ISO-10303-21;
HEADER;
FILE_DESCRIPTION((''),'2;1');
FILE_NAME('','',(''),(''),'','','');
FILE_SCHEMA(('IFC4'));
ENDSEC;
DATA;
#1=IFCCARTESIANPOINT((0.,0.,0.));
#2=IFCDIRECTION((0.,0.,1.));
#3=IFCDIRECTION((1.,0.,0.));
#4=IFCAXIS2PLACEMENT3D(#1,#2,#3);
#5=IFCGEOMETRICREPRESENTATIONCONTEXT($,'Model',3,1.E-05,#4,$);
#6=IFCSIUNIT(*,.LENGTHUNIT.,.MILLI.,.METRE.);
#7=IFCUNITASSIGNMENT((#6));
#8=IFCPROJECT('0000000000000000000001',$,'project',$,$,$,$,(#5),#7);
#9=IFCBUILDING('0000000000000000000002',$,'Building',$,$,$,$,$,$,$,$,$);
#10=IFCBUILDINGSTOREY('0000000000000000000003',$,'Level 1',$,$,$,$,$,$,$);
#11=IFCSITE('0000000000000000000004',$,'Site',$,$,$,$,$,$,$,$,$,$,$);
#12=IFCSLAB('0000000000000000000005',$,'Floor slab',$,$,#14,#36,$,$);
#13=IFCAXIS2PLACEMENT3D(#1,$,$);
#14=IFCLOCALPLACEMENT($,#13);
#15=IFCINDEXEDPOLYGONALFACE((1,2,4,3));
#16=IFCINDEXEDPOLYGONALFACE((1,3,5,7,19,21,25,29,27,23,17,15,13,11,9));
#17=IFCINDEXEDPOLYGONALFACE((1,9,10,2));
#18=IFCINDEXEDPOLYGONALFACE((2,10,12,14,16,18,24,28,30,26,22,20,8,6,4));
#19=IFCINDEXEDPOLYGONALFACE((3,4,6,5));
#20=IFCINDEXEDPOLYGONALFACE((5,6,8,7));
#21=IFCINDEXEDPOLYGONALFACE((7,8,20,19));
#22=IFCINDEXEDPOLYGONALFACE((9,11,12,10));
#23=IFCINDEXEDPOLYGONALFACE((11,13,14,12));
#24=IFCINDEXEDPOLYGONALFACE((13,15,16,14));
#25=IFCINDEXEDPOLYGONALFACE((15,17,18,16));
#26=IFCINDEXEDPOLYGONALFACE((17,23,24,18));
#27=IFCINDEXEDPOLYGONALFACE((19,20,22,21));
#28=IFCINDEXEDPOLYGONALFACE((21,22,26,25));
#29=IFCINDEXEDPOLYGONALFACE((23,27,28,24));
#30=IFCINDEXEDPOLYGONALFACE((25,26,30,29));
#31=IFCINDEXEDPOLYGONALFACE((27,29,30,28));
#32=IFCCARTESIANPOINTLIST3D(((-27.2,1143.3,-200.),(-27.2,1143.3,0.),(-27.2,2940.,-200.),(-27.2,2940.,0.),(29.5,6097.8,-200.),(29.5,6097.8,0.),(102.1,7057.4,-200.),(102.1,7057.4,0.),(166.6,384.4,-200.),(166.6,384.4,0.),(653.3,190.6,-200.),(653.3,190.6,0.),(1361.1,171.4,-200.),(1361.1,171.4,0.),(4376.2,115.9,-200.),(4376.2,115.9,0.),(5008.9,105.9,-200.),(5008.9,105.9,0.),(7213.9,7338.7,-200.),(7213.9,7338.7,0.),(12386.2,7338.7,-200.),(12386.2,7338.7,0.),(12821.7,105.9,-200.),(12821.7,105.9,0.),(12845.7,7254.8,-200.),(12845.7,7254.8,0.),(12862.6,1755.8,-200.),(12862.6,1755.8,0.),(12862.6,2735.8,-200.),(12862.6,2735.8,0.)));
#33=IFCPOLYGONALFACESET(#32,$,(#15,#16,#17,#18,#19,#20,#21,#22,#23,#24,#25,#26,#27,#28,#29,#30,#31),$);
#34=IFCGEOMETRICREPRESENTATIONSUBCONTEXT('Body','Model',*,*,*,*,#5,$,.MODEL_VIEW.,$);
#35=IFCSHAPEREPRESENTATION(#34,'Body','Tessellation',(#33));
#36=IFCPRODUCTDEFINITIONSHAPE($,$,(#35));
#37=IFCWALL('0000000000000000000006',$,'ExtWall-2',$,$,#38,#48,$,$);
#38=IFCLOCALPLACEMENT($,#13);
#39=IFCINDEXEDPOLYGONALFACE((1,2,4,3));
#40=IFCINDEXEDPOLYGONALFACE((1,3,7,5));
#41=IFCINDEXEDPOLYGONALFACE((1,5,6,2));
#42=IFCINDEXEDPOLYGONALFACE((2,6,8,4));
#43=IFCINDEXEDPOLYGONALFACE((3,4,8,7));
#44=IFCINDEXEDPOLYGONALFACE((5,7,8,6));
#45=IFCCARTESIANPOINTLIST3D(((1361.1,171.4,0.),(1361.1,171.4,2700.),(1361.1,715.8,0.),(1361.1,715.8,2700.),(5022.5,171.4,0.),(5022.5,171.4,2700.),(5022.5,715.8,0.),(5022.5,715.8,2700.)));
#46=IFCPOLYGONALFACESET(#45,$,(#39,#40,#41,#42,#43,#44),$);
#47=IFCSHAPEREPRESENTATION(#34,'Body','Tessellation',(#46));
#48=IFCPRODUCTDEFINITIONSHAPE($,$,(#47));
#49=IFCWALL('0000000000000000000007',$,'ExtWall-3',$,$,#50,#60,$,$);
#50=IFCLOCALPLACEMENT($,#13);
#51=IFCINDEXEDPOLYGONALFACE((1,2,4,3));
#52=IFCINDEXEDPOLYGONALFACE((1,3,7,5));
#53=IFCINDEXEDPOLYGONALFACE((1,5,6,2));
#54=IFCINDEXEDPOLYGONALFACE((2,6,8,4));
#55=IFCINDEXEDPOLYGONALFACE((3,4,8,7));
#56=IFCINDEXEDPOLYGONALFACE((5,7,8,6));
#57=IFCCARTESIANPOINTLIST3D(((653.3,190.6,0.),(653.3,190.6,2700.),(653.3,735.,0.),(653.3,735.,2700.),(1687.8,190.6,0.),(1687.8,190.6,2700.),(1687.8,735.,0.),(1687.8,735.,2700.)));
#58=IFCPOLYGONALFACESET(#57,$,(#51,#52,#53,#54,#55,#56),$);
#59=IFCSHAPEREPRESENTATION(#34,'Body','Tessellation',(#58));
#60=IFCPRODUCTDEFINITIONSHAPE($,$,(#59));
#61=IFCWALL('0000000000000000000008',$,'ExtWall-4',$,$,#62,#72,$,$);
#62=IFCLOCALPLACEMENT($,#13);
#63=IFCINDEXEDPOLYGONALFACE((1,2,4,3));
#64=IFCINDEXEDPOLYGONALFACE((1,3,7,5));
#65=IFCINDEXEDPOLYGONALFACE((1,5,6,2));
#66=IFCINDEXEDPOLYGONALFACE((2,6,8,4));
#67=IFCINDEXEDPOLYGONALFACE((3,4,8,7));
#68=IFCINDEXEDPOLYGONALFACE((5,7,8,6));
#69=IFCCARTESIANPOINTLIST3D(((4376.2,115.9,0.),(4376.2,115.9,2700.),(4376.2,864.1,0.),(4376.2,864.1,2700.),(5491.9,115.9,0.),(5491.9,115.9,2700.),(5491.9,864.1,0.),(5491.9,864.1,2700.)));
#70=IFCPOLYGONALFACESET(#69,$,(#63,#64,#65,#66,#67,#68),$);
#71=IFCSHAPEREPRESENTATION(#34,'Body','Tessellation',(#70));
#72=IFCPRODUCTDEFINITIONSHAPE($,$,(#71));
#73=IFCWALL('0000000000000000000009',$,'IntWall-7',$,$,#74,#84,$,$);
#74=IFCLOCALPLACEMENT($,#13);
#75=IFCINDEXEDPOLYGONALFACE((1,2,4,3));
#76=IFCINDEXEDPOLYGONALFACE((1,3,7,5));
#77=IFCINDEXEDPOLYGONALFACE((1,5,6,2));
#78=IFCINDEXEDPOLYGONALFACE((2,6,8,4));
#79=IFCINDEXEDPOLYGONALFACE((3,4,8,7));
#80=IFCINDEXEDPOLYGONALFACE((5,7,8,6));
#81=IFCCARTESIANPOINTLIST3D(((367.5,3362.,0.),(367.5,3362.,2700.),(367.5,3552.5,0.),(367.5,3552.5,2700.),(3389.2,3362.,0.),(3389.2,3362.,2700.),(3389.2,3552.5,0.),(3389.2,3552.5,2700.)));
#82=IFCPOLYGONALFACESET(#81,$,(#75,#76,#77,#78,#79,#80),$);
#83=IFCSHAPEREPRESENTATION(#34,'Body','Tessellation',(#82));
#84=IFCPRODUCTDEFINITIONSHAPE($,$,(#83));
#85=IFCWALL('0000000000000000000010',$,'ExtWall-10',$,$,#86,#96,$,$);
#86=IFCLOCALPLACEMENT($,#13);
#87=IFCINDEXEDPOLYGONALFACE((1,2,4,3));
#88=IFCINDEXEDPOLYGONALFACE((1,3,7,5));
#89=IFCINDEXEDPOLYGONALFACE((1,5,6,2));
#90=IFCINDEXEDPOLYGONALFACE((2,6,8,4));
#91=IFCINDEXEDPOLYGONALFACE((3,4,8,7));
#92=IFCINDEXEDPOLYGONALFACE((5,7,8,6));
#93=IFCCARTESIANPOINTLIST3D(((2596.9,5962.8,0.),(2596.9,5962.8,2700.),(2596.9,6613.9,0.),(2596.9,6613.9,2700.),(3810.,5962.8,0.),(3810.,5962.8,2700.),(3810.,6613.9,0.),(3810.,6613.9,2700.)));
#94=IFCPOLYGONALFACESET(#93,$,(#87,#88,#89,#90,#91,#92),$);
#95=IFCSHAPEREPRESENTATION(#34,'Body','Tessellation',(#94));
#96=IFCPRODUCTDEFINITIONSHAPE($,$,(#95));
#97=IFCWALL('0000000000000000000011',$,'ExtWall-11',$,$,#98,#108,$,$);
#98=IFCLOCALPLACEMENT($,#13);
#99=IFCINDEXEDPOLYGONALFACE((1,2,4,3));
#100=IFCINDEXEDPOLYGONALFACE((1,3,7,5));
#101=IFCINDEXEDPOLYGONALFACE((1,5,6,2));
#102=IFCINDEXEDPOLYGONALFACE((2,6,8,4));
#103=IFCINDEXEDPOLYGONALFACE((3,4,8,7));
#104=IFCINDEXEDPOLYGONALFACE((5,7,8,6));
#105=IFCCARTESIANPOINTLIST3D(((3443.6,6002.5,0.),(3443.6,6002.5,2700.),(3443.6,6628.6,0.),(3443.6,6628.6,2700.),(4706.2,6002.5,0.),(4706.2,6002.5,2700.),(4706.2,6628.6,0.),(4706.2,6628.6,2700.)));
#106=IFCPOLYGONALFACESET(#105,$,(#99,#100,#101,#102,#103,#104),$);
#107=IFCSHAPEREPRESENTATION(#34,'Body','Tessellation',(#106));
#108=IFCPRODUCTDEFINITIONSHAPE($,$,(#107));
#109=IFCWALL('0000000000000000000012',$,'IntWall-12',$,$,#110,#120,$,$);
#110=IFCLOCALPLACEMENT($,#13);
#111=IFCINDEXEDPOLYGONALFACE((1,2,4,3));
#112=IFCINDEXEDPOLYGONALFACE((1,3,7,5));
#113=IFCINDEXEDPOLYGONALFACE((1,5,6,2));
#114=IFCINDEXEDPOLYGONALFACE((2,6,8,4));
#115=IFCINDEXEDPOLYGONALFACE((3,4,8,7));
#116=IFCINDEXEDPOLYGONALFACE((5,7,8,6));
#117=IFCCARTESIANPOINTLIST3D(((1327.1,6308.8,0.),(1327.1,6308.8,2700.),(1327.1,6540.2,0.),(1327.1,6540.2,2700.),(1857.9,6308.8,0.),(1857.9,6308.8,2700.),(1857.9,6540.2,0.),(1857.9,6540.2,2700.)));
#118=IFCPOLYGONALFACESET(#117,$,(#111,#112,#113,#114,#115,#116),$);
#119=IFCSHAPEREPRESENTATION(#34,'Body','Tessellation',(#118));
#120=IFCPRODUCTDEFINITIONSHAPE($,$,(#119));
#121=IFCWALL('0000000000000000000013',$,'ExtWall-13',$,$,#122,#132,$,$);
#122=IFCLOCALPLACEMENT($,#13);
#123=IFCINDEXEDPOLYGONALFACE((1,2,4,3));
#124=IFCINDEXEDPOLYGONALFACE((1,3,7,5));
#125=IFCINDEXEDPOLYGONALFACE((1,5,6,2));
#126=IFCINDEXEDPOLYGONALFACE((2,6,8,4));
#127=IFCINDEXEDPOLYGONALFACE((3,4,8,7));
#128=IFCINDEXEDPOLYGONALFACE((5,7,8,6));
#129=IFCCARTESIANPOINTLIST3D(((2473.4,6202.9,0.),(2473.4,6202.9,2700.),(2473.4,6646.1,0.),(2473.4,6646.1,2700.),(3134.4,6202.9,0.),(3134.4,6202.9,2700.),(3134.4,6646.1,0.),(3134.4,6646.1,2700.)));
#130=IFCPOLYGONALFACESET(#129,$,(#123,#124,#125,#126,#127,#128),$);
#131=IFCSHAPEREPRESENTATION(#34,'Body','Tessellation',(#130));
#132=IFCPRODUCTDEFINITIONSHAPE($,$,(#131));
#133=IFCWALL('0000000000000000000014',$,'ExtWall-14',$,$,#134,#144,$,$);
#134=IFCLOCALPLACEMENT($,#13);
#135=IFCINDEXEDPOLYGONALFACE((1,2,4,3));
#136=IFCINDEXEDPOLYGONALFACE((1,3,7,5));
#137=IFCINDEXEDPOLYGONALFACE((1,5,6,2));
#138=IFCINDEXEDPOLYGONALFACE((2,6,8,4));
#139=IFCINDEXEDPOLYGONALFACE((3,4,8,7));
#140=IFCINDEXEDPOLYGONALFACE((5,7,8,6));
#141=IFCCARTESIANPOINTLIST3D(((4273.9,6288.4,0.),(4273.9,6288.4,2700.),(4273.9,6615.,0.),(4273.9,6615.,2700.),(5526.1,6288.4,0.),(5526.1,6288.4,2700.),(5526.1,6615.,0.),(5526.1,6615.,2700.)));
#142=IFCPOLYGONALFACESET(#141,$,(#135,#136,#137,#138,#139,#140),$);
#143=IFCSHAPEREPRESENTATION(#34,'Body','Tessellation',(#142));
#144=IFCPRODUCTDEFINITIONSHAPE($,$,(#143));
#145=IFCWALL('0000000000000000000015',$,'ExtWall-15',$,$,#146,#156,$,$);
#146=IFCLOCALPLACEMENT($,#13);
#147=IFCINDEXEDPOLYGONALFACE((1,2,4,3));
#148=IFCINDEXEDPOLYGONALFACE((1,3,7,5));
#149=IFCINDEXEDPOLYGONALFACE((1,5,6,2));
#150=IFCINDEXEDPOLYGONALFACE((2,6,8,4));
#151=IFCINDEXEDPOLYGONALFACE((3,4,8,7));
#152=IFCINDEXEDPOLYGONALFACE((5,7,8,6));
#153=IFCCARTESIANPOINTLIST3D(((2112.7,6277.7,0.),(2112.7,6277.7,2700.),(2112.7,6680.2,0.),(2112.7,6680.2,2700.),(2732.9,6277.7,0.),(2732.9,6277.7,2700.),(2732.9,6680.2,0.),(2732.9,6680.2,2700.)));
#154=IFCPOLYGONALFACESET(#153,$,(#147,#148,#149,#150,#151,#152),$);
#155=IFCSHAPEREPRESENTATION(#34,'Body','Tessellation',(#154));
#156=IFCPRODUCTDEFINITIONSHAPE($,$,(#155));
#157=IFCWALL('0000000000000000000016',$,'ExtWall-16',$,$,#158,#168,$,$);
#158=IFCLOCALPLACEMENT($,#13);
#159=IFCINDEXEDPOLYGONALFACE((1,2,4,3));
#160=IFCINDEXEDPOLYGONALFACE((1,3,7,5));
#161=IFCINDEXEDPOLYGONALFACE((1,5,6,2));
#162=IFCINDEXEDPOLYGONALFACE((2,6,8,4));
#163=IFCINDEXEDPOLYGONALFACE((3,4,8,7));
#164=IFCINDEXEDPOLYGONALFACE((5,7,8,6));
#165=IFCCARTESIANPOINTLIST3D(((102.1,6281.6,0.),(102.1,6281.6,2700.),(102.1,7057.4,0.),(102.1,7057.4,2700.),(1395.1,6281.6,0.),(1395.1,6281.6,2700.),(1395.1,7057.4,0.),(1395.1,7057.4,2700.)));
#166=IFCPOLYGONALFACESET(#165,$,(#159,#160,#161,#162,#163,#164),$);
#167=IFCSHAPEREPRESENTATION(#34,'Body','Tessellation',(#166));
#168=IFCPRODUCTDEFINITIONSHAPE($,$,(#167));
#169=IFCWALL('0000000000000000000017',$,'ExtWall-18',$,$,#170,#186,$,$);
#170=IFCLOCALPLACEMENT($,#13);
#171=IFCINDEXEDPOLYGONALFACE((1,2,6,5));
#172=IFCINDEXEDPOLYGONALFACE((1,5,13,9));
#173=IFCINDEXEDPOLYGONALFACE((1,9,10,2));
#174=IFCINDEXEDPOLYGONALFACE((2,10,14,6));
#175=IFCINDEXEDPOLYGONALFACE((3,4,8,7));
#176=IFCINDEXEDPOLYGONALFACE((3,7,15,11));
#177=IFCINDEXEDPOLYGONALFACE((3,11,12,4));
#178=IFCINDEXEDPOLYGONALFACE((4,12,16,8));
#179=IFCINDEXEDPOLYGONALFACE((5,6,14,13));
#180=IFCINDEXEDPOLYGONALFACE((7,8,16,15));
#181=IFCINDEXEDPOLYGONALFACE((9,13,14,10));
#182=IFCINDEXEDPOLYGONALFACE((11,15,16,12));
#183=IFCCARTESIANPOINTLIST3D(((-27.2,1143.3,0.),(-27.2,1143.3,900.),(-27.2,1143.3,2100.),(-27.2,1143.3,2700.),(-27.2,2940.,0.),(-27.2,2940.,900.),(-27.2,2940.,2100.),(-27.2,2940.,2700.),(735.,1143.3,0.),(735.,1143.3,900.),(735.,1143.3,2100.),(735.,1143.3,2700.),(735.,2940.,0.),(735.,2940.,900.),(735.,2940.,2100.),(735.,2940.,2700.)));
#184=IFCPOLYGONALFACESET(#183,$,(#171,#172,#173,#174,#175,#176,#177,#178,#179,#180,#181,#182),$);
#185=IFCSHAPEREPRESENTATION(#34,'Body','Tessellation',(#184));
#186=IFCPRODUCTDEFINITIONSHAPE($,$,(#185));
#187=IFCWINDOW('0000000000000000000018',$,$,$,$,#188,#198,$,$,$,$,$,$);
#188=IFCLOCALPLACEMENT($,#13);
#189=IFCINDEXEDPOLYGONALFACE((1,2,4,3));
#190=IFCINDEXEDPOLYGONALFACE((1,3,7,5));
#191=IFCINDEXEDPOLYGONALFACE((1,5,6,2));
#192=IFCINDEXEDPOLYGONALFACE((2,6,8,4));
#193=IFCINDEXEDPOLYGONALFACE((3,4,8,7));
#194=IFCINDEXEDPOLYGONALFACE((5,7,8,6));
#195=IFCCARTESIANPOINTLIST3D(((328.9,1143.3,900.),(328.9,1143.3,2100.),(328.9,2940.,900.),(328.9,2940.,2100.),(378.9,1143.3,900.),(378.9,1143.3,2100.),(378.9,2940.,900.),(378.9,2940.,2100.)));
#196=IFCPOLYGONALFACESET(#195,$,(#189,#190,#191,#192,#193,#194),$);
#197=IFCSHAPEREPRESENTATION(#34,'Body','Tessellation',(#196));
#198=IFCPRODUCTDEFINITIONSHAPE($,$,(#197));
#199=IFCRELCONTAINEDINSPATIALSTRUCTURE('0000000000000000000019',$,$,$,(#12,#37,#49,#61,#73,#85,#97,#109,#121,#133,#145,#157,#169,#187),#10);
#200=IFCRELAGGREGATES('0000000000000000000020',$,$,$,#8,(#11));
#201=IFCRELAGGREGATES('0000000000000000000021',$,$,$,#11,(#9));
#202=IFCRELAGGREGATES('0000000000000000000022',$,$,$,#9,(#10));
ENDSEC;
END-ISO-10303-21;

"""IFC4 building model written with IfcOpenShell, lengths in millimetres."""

from ifc_helpers import new_model, si_unit, frame, origin_with_axes, place, context, subcontext, project, spatial, indexed_curve, outline, extrude, element, fill, save


model = new_model("IFC4")

# Units and contexts
model_context = context("Model", 3, precision=1e-05, world=origin_with_axes())
body_context = subcontext(model_context, "Body", "Model", "MODEL_VIEW")
ifc_project = project(units=[si_unit("LENGTHUNIT", "METRE", prefix="MILLI")], contexts=[model_context])

# Site, building, storey
site = spatial("IfcSite", under=ifc_project, Name="Site")
building = spatial("IfcBuilding", under=site, Name="Building")
storey = spatial("IfcBuildingStorey", under=building, Name="Level 1")

# Slab
slab_placement = place(None, frame((0.0, 0.0, -200.0), z_axis=(0.0, 0.0, 1.0), x_axis=(1.0, 0.0, 0.0)))
element("IfcSlab", 1, at=slab_placement, inside=storey, Name="Floor slab", context=body_context, shape_type="SweptSolid", body=[
    extrude(outline(indexed_curve([(5008.9, 105.9), (4376.2, 115.9), (1361.1, 171.4), (653.3, 190.6), (166.6, 384.4), (-27.2, 1143.3), (-27.2, 2940.0), (29.5, 6097.8), (102.1, 7057.4), (7213.9, 7338.7), (12386.2, 7338.7), (12845.7, 7254.8), (12862.6, 2735.8), (12862.6, 1755.8), (12821.7, 105.9)])), None, (0.0, 0.0, 1.0), 200.0),
])

# Walls
wall_1_placement = place(None, frame((1361.1, 443.6, 0.0), z_axis=(0.0, 0.0, 1.0), x_axis=(1.0, 0.0, 0.0)))
element("IfcWall", 2, at=wall_1_placement, inside=storey, Name="ExtWall-2", context=body_context, shape_type="SweptSolid", body=[
    extrude(outline(indexed_curve([(0.0, 0.0), (0.0, 544.4), (3661.4, 544.4), (3661.4, 0.0), (0.0, 0.0)], self_intersect=False)), frame((0.0, -272.2, 0.0), z_axis=(0.0, 0.0, 1.0), x_axis=(1.0, 0.0, 0.0)), (0.0, 0.0, 1.0), 2700.0),
])
wall_2_placement = place(None, frame((653.3, 462.8, 0.0), z_axis=(0.0, 0.0, 1.0), x_axis=(1.0, 0.0, 0.0)))
element("IfcWall", 3, at=wall_2_placement, inside=storey, Name="ExtWall-3", context=body_context, shape_type="SweptSolid", body=[
    extrude(outline(indexed_curve([(0.0, 0.0), (0.0, 544.4), (1034.5, 544.4), (1034.5, 0.0), (0.0, 0.0)], self_intersect=False)), frame((0.0, -272.2, 0.0), z_axis=(0.0, 0.0, 1.0), x_axis=(1.0, 0.0, 0.0)), (0.0, 0.0, 1.0), 2700.0),
])
wall_3_placement = place(None, frame((4376.2, 490.0, 0.0), z_axis=(0.0, 0.0, 1.0), x_axis=(1.0, 0.0, 0.0)))
element("IfcWall", 4, at=wall_3_placement, inside=storey, Name="ExtWall-4", context=body_context, shape_type="SweptSolid", body=[
    extrude(outline(indexed_curve([(0.0, 0.0), (0.0, 748.3), (1115.8, 748.3), (1115.8, 0.0), (0.0, 0.0)], self_intersect=False)), frame((0.0, -374.1, 0.0), z_axis=(0.0, 0.0, 1.0), x_axis=(1.0, 0.0, 0.0)), (0.0, 0.0, 1.0), 2700.0),
])
wall_4_placement = place(None, frame((367.5, 3457.2, 0.0), z_axis=(0.0, 0.0, 1.0), x_axis=(1.0, 0.0, 0.0)))
element("IfcWall", 5, at=wall_4_placement, inside=storey, Name="IntWall-7", context=body_context, shape_type="SweptSolid", body=[
    extrude(outline(indexed_curve([(0.0, 0.0), (0.0, 190.6), (3021.7, 190.6), (3021.7, 0.0), (0.0, 0.0)], self_intersect=False)), frame((0.0, -95.3, 0.0), z_axis=(0.0, 0.0, 1.0), x_axis=(1.0, 0.0, 0.0)), (0.0, 0.0, 1.0), 2700.0),
])
wall_5_placement = place(None, frame((2596.9, 6288.4, 0.0), z_axis=(0.0, 0.0, 1.0), x_axis=(1.0, 0.0, 0.0)))
element("IfcWall", 6, at=wall_5_placement, inside=storey, Name="ExtWall-10", context=body_context, shape_type="SweptSolid", body=[
    extrude(outline(indexed_curve([(0.0, 0.0), (0.0, 651.2), (1213.2, 651.2), (1213.2, 0.0), (0.0, 0.0)], self_intersect=False)), frame((0.0, -325.6, 0.0), z_axis=(0.0, 0.0, 1.0), x_axis=(1.0, 0.0, 0.0)), (0.0, 0.0, 1.0), 2700.0),
])
wall_6_placement = place(None, frame((3443.6, 6315.6, 0.0), z_axis=(0.0, 0.0, 1.0), x_axis=(1.0, 0.0, 0.0)))
element("IfcWall", 7, at=wall_6_placement, inside=storey, Name="ExtWall-11", context=body_context, shape_type="SweptSolid", body=[
    extrude(outline(indexed_curve([(0.0, 0.0), (0.0, 626.1), (1262.6, 626.1), (1262.6, 0.0), (0.0, 0.0)], self_intersect=False)), frame((0.0, -313.1, 0.0), z_axis=(0.0, 0.0, 1.0), x_axis=(1.0, 0.0, 0.0)), (0.0, 0.0, 1.0), 2700.0),
])
wall_7_placement = place(None, frame((1327.1, 6424.5, 0.0), z_axis=(0.0, 0.0, 1.0), x_axis=(1.0, 0.0, 0.0)))
element("IfcWall", 8, at=wall_7_placement, inside=storey, Name="IntWall-12", context=body_context, shape_type="SweptSolid", body=[
    extrude(outline(indexed_curve([(0.0, 0.0), (0.0, 231.4), (530.8, 231.4), (530.8, 0.0), (0.0, 0.0)], self_intersect=False)), frame((0.0, -115.7, 0.0), z_axis=(0.0, 0.0, 1.0), x_axis=(1.0, 0.0, 0.0)), (0.0, 0.0, 1.0), 2700.0),
])
wall_8_placement = place(None, frame((2473.4, 6424.5, 0.0), z_axis=(0.0, 0.0, 1.0), x_axis=(1.0, 0.0, 0.0)))
element("IfcWall", 9, at=wall_8_placement, inside=storey, Name="ExtWall-13", context=body_context, shape_type="SweptSolid", body=[
    extrude(outline(indexed_curve([(0.0, 0.0), (0.0, 443.2), (661.0, 443.2), (661.0, 0.0), (0.0, 0.0)], self_intersect=False)), frame((0.0, -221.6, 0.0), z_axis=(0.0, 0.0, 1.0), x_axis=(1.0, 0.0, 0.0)), (0.0, 0.0, 1.0), 2700.0),
])
wall_9_placement = place(None, frame((4273.9, 6451.7, 0.0), z_axis=(0.0, 0.0, 1.0), x_axis=(1.0, 0.0, 0.0)))
element("IfcWall", 10, at=wall_9_placement, inside=storey, Name="ExtWall-14", context=body_context, shape_type="SweptSolid", body=[
    extrude(outline(indexed_curve([(0.0, 0.0), (0.0, 326.7), (1252.2, 326.7), (1252.2, 0.0), (0.0, 0.0)], self_intersect=False)), frame((0.0, -163.3, 0.0), z_axis=(0.0, 0.0, 1.0), x_axis=(1.0, 0.0, 0.0)), (0.0, 0.0, 1.0), 2700.0),
])
wall_10_placement = place(None, frame((2112.7, 6478.9, 0.0), z_axis=(0.0, 0.0, 1.0), x_axis=(1.0, 0.0, 0.0)))
element("IfcWall", 11, at=wall_10_placement, inside=storey, Name="ExtWall-15", context=body_context, shape_type="SweptSolid", body=[
    extrude(outline(indexed_curve([(0.0, 0.0), (0.0, 402.5), (620.2, 402.5), (620.2, 0.0), (0.0, 0.0)], self_intersect=False)), frame((0.0, -201.2, 0.0), z_axis=(0.0, 0.0, 1.0), x_axis=(1.0, 0.0, 0.0)), (0.0, 0.0, 1.0), 2700.0),
])
wall_11_placement = place(None, frame((102.1, 6669.5, 0.0), z_axis=(0.0, 0.0, 1.0), x_axis=(1.0, 0.0, 0.0)))
element("IfcWall", 12, at=wall_11_placement, inside=storey, Name="ExtWall-16", context=body_context, shape_type="SweptSolid", body=[
    extrude(outline(indexed_curve([(0.0, 0.0), (0.0, 775.8), (1293.1, 775.8), (1293.1, 0.0), (0.0, 0.0)], self_intersect=False)), frame((0.0, -387.9, 0.0), z_axis=(0.0, 0.0, 1.0), x_axis=(1.0, 0.0, 0.0)), (0.0, 0.0, 1.0), 2700.0),
])

# Wall, opening, window
wall_12_placement = place(None, frame((353.9, 1143.3, 0.0), z_axis=(0.0, 0.0, 1.0), x_axis=(0.0, 1.0, 0.0)))
wall_12 = element("IfcWall", 13, at=wall_12_placement, inside=storey, Name="ExtWall-18", context=body_context, shape_type="SweptSolid", body=[
    extrude(outline(indexed_curve([(0.0, 0.0), (0.0, 762.2), (1796.7, 762.2), (1796.7, 0.0), (0.0, 0.0)], self_intersect=False)), frame((0.0, -381.1, 0.0), z_axis=(0.0, 0.0, 1.0), x_axis=(1.0, 0.0, 0.0)), (0.0, 0.0, 1.0), 2700.0),
])
opening_1_placement = place(wall_12_placement, frame((0.0, 0.0, 900.0), z_axis=(0.0, 0.0, 1.0), x_axis=(1.0, 0.0, 0.0)))
opening_1 = element("IfcOpeningElement", 14, at=opening_1_placement, cuts=wall_12, context=body_context, shape_type="SweptSolid", body=[
    extrude(outline(indexed_curve([(0.0, 0.0), (0.0, 862.2), (1796.7, 862.2), (1796.7, 0.0), (0.0, 0.0)], self_intersect=False)), frame((0.0, -431.1, 0.0), z_axis=(0.0, 0.0, 1.0), x_axis=(1.0, 0.0, 0.0)), (0.0, 0.0, 1.0), 1200.0),
])
window_1_placement = place(opening_1_placement, origin_with_axes())
window_1 = element("IfcWindow", 15, at=window_1_placement, inside=storey, context=body_context, shape_type="SweptSolid", body=[
    extrude(outline(indexed_curve([(0.0, 0.0), (0.0, 50.0), (1796.7, 50.0), (1796.7, 0.0), (0.0, 0.0)], self_intersect=False)), frame((0.0, -25.0, 0.0), z_axis=(0.0, 0.0, 1.0), x_axis=(1.0, 0.0, 0.0)), (0.0, 0.0, 1.0), 1200.0),
])
fill(opening_1, window_1)

save(model, "model.ifc")
